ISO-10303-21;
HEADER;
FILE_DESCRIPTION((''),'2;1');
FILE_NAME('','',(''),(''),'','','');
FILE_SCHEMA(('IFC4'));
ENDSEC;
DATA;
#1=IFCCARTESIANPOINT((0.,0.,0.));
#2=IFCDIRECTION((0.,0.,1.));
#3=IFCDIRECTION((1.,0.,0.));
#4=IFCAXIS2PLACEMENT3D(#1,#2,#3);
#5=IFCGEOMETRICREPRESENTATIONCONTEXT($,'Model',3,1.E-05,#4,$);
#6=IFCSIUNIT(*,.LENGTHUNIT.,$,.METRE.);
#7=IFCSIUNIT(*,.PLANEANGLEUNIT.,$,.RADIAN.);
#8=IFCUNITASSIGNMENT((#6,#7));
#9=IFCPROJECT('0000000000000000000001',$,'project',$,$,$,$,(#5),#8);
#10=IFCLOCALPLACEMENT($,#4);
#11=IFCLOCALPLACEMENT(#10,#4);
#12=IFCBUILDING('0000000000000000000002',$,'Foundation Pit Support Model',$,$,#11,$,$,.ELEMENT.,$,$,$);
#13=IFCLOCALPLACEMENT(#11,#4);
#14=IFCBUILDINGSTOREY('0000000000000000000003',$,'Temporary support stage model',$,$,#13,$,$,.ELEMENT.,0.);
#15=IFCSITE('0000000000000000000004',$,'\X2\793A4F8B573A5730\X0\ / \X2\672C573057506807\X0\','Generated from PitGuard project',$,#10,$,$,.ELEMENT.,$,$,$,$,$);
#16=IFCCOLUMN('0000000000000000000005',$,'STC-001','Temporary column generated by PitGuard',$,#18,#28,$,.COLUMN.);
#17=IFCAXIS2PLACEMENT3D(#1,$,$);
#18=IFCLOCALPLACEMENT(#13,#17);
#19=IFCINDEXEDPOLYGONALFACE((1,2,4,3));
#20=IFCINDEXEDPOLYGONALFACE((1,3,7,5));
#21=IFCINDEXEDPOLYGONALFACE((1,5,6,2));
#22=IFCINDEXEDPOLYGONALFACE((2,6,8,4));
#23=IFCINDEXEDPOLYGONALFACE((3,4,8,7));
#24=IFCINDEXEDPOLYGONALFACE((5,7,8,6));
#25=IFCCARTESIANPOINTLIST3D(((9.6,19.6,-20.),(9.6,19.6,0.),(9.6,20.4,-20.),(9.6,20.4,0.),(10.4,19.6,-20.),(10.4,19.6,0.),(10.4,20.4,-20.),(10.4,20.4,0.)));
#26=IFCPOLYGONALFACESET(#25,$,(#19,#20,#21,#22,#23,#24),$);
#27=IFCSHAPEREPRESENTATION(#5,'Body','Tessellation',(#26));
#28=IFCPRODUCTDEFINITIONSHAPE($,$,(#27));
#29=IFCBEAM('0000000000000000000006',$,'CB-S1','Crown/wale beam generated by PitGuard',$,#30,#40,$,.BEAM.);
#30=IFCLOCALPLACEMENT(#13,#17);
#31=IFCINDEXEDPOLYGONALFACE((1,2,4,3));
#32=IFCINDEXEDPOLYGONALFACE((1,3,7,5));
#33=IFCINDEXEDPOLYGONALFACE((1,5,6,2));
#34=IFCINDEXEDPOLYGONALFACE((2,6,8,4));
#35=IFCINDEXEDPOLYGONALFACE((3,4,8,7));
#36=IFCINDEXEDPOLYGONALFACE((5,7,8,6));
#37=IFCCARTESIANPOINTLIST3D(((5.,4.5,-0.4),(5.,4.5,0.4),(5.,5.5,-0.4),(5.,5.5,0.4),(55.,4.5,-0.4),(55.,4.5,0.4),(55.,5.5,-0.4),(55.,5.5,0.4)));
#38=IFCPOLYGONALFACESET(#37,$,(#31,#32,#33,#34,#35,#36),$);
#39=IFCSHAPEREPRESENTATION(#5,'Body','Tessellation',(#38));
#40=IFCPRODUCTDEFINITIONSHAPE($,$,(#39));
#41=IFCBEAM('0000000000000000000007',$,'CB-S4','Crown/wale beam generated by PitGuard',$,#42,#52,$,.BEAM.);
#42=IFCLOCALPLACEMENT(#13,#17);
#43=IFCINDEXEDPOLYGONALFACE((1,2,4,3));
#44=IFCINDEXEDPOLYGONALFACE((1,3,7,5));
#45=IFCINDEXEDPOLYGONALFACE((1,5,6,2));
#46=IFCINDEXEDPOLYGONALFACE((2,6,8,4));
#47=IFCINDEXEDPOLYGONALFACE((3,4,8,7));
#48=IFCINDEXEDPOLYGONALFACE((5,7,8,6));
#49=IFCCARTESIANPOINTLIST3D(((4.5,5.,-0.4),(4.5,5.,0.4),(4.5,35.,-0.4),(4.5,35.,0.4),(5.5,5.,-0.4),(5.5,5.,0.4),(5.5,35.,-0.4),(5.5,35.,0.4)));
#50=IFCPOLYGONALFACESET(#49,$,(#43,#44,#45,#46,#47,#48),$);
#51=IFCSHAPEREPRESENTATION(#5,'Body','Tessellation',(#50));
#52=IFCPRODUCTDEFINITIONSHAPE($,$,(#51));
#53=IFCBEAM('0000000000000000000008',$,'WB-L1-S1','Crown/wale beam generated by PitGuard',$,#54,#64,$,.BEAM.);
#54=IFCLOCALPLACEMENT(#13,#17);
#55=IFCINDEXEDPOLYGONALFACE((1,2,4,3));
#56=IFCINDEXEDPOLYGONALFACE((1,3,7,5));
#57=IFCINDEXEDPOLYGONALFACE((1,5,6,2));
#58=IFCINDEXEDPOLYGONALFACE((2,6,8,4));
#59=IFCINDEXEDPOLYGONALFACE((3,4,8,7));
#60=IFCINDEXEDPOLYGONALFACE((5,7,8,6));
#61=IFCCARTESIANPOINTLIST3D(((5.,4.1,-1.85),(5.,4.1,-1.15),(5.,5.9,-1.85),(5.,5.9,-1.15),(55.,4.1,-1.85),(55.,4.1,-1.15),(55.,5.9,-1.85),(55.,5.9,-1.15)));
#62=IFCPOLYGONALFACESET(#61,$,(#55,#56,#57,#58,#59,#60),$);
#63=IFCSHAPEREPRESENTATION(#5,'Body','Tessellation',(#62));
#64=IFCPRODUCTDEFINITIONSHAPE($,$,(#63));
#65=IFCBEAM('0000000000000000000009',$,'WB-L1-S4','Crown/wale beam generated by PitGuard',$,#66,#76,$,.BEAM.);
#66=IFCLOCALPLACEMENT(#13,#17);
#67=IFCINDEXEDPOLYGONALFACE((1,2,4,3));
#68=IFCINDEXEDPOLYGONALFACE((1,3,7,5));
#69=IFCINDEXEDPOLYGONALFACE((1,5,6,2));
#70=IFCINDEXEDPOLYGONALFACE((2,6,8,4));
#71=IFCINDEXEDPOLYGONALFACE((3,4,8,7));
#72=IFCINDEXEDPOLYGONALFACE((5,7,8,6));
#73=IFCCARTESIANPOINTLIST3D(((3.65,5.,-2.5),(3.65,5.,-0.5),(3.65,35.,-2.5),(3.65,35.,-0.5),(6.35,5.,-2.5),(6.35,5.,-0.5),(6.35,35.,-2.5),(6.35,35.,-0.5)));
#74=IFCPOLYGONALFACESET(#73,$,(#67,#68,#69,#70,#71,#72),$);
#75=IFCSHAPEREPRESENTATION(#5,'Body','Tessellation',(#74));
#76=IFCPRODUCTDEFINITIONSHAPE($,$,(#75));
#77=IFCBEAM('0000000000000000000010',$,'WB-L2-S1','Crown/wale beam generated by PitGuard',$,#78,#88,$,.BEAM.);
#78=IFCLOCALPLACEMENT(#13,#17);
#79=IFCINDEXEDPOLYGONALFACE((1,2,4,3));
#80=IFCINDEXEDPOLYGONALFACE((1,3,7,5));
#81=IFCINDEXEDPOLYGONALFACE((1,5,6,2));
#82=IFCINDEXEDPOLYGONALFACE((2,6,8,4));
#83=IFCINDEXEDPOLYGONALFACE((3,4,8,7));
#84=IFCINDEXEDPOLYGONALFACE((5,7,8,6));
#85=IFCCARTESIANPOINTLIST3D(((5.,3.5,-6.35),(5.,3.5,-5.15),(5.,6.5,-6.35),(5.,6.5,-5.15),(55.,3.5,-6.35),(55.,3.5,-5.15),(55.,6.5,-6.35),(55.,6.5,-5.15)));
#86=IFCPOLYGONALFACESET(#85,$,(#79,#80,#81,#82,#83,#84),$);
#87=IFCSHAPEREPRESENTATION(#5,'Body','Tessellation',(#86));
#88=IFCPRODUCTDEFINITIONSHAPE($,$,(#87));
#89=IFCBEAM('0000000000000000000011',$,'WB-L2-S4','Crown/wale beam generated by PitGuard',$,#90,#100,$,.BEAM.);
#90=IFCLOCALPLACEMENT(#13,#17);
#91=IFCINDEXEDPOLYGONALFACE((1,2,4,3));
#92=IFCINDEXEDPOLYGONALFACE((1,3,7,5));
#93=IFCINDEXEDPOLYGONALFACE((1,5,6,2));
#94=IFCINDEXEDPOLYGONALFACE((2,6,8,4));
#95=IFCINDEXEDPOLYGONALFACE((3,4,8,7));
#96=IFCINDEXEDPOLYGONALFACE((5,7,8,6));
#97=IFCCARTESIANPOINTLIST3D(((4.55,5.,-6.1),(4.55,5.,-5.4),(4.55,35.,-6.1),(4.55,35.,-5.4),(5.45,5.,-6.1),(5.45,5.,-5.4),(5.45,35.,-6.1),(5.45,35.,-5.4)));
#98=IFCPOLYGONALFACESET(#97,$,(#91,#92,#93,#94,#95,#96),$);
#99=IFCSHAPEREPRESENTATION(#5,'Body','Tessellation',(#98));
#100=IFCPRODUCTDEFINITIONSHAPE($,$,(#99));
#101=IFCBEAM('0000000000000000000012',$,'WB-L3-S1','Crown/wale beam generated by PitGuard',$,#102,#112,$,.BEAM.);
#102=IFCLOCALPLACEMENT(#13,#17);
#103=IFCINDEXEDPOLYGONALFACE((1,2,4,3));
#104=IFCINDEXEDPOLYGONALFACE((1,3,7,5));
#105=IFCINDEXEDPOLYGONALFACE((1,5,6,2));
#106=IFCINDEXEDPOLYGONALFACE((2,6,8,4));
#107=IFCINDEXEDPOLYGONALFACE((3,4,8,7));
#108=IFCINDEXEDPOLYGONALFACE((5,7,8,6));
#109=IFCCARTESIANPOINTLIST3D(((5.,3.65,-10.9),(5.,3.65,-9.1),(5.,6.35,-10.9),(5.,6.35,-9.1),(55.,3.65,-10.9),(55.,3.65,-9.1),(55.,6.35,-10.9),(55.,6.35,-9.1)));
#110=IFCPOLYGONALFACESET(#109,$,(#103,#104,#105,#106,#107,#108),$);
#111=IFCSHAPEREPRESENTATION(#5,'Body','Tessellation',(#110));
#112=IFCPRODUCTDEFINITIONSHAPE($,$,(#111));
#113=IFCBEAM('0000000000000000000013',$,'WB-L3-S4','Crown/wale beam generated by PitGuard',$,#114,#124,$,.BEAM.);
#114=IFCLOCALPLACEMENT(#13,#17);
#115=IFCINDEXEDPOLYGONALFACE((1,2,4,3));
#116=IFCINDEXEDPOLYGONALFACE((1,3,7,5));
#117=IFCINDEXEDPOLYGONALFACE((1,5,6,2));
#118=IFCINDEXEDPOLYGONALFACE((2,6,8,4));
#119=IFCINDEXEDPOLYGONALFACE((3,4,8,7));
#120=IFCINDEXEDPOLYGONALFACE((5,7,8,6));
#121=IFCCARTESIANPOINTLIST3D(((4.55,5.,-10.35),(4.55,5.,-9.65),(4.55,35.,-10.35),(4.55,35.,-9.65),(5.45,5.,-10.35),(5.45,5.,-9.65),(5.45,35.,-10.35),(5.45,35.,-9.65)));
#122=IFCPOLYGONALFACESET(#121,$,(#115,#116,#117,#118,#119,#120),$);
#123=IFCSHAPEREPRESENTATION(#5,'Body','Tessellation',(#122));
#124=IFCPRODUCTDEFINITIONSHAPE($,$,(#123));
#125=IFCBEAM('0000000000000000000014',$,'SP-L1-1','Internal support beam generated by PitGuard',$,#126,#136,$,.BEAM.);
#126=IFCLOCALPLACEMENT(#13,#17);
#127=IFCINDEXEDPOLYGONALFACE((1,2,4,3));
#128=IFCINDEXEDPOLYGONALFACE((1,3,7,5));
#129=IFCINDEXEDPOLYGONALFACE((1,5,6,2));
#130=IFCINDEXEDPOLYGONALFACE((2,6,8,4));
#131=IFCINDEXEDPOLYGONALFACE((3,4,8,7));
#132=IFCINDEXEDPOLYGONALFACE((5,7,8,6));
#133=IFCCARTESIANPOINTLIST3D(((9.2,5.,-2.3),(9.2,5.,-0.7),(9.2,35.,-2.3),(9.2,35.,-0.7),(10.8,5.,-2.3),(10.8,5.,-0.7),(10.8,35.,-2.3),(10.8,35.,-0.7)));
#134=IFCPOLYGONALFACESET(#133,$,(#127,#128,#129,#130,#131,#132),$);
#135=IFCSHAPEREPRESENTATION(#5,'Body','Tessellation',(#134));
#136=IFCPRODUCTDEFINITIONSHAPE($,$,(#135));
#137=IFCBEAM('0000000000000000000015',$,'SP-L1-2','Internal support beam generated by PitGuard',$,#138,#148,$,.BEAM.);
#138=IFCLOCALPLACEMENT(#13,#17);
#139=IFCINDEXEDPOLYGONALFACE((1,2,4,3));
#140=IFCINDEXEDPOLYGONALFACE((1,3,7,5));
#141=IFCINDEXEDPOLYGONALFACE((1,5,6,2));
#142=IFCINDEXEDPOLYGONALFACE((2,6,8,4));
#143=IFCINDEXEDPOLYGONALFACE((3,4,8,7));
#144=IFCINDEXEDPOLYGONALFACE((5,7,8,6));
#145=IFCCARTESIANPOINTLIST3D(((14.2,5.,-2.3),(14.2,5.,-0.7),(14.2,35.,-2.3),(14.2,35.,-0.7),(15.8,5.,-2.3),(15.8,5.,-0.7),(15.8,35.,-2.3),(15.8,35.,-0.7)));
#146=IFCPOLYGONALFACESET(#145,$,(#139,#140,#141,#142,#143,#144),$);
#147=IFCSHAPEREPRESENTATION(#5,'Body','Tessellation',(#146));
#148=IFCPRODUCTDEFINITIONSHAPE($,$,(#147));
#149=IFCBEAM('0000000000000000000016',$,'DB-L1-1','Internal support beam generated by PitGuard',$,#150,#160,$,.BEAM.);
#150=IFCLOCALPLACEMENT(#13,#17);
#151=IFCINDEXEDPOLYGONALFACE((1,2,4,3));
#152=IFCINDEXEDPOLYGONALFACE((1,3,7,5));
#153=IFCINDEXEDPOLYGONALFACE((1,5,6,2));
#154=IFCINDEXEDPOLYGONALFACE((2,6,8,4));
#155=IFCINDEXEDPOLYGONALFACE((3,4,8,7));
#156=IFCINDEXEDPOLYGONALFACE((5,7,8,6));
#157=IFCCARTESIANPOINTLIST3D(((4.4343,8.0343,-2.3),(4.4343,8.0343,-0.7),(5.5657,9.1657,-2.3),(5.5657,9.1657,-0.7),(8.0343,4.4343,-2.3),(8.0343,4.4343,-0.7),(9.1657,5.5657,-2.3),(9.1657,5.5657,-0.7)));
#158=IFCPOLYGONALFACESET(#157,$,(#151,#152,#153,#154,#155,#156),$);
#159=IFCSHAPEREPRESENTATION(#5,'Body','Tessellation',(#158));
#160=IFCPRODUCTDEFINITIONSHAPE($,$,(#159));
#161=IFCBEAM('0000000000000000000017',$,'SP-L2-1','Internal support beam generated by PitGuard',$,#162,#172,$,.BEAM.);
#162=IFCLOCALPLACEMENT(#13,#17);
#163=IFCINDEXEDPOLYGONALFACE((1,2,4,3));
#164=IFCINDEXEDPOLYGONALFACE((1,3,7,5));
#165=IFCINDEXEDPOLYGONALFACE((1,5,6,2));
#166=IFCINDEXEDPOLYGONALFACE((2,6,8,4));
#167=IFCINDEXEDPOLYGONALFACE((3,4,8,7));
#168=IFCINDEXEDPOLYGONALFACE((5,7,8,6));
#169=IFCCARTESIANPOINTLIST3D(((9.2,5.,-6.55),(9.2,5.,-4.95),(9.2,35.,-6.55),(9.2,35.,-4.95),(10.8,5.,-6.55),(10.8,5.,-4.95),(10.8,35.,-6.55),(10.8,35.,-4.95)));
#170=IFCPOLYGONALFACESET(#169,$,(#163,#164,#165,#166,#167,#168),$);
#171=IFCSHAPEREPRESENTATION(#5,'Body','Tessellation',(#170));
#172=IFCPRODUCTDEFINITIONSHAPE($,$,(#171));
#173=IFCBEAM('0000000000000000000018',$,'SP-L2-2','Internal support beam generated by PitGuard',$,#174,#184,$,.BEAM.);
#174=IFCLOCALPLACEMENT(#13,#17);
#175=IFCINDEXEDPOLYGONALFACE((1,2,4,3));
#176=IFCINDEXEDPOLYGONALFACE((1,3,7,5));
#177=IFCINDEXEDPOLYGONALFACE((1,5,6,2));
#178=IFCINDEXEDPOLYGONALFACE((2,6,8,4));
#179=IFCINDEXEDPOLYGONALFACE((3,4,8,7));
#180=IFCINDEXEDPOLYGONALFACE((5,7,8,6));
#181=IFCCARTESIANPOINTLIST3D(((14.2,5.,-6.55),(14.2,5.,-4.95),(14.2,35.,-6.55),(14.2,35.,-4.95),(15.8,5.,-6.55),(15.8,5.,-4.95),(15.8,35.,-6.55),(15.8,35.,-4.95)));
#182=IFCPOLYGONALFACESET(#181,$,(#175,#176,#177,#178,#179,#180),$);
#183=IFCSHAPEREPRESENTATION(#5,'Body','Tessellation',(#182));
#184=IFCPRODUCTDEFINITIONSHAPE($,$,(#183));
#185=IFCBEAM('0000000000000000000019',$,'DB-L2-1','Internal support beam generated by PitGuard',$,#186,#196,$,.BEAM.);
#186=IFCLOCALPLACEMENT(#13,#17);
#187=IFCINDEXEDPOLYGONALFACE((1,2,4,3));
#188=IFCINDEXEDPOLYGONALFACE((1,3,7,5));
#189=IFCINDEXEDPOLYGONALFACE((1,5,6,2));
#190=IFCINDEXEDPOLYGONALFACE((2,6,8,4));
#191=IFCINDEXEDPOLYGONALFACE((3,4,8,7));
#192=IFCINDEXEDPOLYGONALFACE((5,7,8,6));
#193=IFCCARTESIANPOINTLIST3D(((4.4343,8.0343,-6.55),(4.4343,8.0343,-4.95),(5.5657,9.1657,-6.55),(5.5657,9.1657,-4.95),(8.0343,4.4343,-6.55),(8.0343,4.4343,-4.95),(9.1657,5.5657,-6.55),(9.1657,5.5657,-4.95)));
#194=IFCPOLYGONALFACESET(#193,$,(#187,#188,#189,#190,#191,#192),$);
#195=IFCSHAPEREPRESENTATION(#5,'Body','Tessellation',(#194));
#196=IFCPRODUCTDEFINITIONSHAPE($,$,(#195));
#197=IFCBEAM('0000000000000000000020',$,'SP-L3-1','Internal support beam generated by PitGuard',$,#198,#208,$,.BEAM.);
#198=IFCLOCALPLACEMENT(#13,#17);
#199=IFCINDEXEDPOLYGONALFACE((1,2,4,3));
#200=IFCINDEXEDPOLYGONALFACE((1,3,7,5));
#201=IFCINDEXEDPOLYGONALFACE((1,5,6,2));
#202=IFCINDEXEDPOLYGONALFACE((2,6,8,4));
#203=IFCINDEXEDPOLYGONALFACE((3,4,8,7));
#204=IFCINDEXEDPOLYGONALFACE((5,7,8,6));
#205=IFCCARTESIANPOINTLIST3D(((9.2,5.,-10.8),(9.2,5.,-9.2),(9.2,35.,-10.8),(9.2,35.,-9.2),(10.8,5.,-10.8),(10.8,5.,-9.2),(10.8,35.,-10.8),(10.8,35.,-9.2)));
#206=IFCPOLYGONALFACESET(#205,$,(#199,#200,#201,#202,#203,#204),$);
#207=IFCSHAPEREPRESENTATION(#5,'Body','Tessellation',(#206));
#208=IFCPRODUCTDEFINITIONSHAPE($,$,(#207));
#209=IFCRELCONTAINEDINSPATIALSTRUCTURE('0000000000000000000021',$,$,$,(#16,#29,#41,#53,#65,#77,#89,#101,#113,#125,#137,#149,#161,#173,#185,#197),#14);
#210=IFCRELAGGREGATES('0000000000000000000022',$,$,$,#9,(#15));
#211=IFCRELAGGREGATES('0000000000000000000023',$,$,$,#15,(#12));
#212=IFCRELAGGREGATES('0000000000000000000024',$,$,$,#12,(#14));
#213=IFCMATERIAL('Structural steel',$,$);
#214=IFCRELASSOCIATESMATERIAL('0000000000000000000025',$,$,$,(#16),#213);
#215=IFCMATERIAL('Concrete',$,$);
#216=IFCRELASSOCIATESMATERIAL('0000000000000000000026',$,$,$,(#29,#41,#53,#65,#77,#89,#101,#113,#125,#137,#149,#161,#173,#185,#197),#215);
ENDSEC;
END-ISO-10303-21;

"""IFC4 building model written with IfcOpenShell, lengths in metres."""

from ifc_helpers import new_model, si_unit, frame, origin_with_axes, origin_2d, place, context, project, spatial, rectangle, extrude, material, element, save


model = new_model("IFC4")

# Units and contexts
model_context = context("Model", 3, precision=1e-05, world=origin_with_axes())
ifc_project = project(units=[si_unit("LENGTHUNIT", "METRE"), si_unit("PLANEANGLEUNIT", "RADIAN")], contexts=[model_context])

# Site, building, storey
site_placement = place(None, origin_with_axes())
site = spatial("IfcSite", under=ifc_project, at=site_placement, Name="示例场地 / 本地坐标", Description="Generated from PitGuard project", CompositionType="ELEMENT")
building_placement = place(site_placement, origin_with_axes())
building = spatial("IfcBuilding", under=site, at=building_placement, Name="Foundation Pit Support Model", CompositionType="ELEMENT")
storey_placement = place(building_placement, origin_with_axes())
storey = spatial("IfcBuildingStorey", under=building, at=storey_placement, Name="Temporary support stage model", CompositionType="ELEMENT", Elevation=0.0)

# Column
ifc_material_1 = material(Name="Structural steel")
column_placement = place(storey_placement, frame((10.0, 20.0, -20.0), z_axis=(0.0, 0.0, 1.0), x_axis=(1.0, 0.0, 0.0)))
element("IfcColumn", 1, at=column_placement, inside=storey, material=ifc_material_1, Name="STC-001", Description="Temporary column generated by PitGuard", PredefinedType="COLUMN", context=model_context, shape_type="SweptSolid", body=[
    extrude(rectangle(XDim=0.8, YDim=0.8, at=origin_2d()), origin_with_axes(), (0.0, 0.0, 1.0), 20.0),
])

# Beams
ifc_material_2 = material(Name="Concrete")
beam_1_placement = place(storey_placement, frame((30.0, 5.0, -0.4), z_axis=(0.0, 0.0, 1.0), x_axis=(1.0, 0.0, 0.0)))
element("IfcBeam", 2, at=beam_1_placement, inside=storey, material=ifc_material_2, Name="CB-S1", Description="Crown/wale beam generated by PitGuard", PredefinedType="BEAM", context=model_context, shape_type="SweptSolid", body=[
    extrude(rectangle(XDim=50.0, YDim=1.0, at=origin_2d()), origin_with_axes(), (0.0, 0.0, 1.0), 0.8),
])
beam_2_placement = place(storey_placement, frame((5.0, 20.0, -0.4), z_axis=(0.0, 0.0, 1.0), x_axis=(0.0, -1.0, 0.0)))
element("IfcBeam", 3, at=beam_2_placement, inside=storey, material=ifc_material_2, Name="CB-S4", Description="Crown/wale beam generated by PitGuard", PredefinedType="BEAM", context=model_context, shape_type="SweptSolid", body=[
    extrude(rectangle(XDim=30.0, YDim=1.0, at=origin_2d()), origin_with_axes(), (0.0, 0.0, 1.0), 0.8),
])
beam_3_placement = place(storey_placement, frame((30.0, 5.0, -1.85), z_axis=(0.0, 0.0, 1.0), x_axis=(1.0, 0.0, 0.0)))
element("IfcBeam", 4, at=beam_3_placement, inside=storey, material=ifc_material_2, Name="WB-L1-S1", Description="Crown/wale beam generated by PitGuard", PredefinedType="BEAM", context=model_context, shape_type="SweptSolid", body=[
    extrude(rectangle(XDim=50.0, YDim=1.8, at=origin_2d()), origin_with_axes(), (0.0, 0.0, 1.0), 0.7),
])
beam_4_placement = place(storey_placement, frame((5.0, 20.0, -2.5), z_axis=(0.0, 0.0, 1.0), x_axis=(0.0, -1.0, 0.0)))
element("IfcBeam", 5, at=beam_4_placement, inside=storey, material=ifc_material_2, Name="WB-L1-S4", Description="Crown/wale beam generated by PitGuard", PredefinedType="BEAM", context=model_context, shape_type="SweptSolid", body=[
    extrude(rectangle(XDim=30.0, YDim=2.7, at=origin_2d()), origin_with_axes(), (0.0, 0.0, 1.0), 2.0),
])
beam_5_placement = place(storey_placement, frame((30.0, 5.0, -6.35), z_axis=(0.0, 0.0, 1.0), x_axis=(1.0, 0.0, 0.0)))
element("IfcBeam", 6, at=beam_5_placement, inside=storey, material=ifc_material_2, Name="WB-L2-S1", Description="Crown/wale beam generated by PitGuard", PredefinedType="BEAM", context=model_context, shape_type="SweptSolid", body=[
    extrude(rectangle(XDim=50.0, YDim=3.0, at=origin_2d()), origin_with_axes(), (0.0, 0.0, 1.0), 1.2),
])
beam_6_placement = place(storey_placement, frame((5.0, 20.0, -6.1), z_axis=(0.0, 0.0, 1.0), x_axis=(0.0, -1.0, 0.0)))
element("IfcBeam", 7, at=beam_6_placement, inside=storey, material=ifc_material_2, Name="WB-L2-S4", Description="Crown/wale beam generated by PitGuard", PredefinedType="BEAM", context=model_context, shape_type="SweptSolid", body=[
    extrude(rectangle(XDim=30.0, YDim=0.9, at=origin_2d()), origin_with_axes(), (0.0, 0.0, 1.0), 0.7),
])
beam_7_placement = place(storey_placement, frame((30.0, 5.0, -10.9), z_axis=(0.0, 0.0, 1.0), x_axis=(1.0, 0.0, 0.0)))
element("IfcBeam", 8, at=beam_7_placement, inside=storey, material=ifc_material_2, Name="WB-L3-S1", Description="Crown/wale beam generated by PitGuard", PredefinedType="BEAM", context=model_context, shape_type="SweptSolid", body=[
    extrude(rectangle(XDim=50.0, YDim=2.7, at=origin_2d()), origin_with_axes(), (0.0, 0.0, 1.0), 1.8),
])
beam_8_placement = place(storey_placement, frame((5.0, 20.0, -10.35), z_axis=(0.0, 0.0, 1.0), x_axis=(0.0, -1.0, 0.0)))
element("IfcBeam", 9, at=beam_8_placement, inside=storey, material=ifc_material_2, Name="WB-L3-S4", Description="Crown/wale beam generated by PitGuard", PredefinedType="BEAM", context=model_context, shape_type="SweptSolid", body=[
    extrude(rectangle(XDim=30.0, YDim=0.9, at=origin_2d()), origin_with_axes(), (0.0, 0.0, 1.0), 0.7),
])
for number, where, z_axis, x_axis, name in (
    (10, (10.0, 20.0, -2.3), (0.0, 0.0, 1.0), (0.0, 1.0, 0.0), "SP-L1-1"),
    (11, (15.0, 20.0, -2.3), (0.0, 0.0, 1.0), (0.0, 1.0, 0.0), "SP-L1-2"),
):
    element("IfcBeam", number, at=place(storey_placement, frame(where, z_axis=z_axis, x_axis=x_axis)), inside=storey, material=ifc_material_2, Name=name, Description="Internal support beam generated by PitGuard", PredefinedType="BEAM", context=model_context, shape_type="SweptSolid", body=[
        extrude(rectangle(XDim=30.0, YDim=1.6, at=origin_2d()), origin_with_axes(), (0.0, 0.0, 1.0), 1.6),
    ])
beam_9_placement = place(storey_placement, frame((6.8, 6.8, -2.3), z_axis=(0.0, 0.0, 1.0), x_axis=(0.707107, -0.707107, 0.0)))
element("IfcBeam", 12, at=beam_9_placement, inside=storey, material=ifc_material_2, Name="DB-L1-1", Description="Internal support beam generated by PitGuard", PredefinedType="BEAM", context=model_context, shape_type="SweptSolid", body=[
    extrude(rectangle(XDim=5.0912, YDim=1.6, at=origin_2d()), origin_with_axes(), (0.0, 0.0, 1.0), 1.6),
])
for number, where, z_axis, x_axis, name in (
    (13, (10.0, 20.0, -6.55), (0.0, 0.0, 1.0), (0.0, 1.0, 0.0), "SP-L2-1"),
    (14, (15.0, 20.0, -6.55), (0.0, 0.0, 1.0), (0.0, 1.0, 0.0), "SP-L2-2"),
):
    element("IfcBeam", number, at=place(storey_placement, frame(where, z_axis=z_axis, x_axis=x_axis)), inside=storey, material=ifc_material_2, Name=name, Description="Internal support beam generated by PitGuard", PredefinedType="BEAM", context=model_context, shape_type="SweptSolid", body=[
        extrude(rectangle(XDim=30.0, YDim=1.6, at=origin_2d()), origin_with_axes(), (0.0, 0.0, 1.0), 1.6),
    ])
beam_10_placement = place(storey_placement, frame((6.8, 6.8, -6.55), z_axis=(0.0, 0.0, 1.0), x_axis=(0.707107, -0.707107, 0.0)))
element("IfcBeam", 15, at=beam_10_placement, inside=storey, material=ifc_material_2, Name="DB-L2-1", Description="Internal support beam generated by PitGuard", PredefinedType="BEAM", context=model_context, shape_type="SweptSolid", body=[
    extrude(rectangle(XDim=5.0912, YDim=1.6, at=origin_2d()), origin_with_axes(), (0.0, 0.0, 1.0), 1.6),
])
beam_11_placement = place(storey_placement, frame((10.0, 20.0, -10.8), z_axis=(0.0, 0.0, 1.0), x_axis=(0.0, 1.0, 0.0)))
element("IfcBeam", 16, at=beam_11_placement, inside=storey, material=ifc_material_2, Name="SP-L3-1", Description="Internal support beam generated by PitGuard", PredefinedType="BEAM", context=model_context, shape_type="SweptSolid", body=[
    extrude(rectangle(XDim=30.0, YDim=1.6, at=origin_2d()), origin_with_axes(), (0.0, 0.0, 1.0), 1.6),
])

save(model, "model.ifc")
